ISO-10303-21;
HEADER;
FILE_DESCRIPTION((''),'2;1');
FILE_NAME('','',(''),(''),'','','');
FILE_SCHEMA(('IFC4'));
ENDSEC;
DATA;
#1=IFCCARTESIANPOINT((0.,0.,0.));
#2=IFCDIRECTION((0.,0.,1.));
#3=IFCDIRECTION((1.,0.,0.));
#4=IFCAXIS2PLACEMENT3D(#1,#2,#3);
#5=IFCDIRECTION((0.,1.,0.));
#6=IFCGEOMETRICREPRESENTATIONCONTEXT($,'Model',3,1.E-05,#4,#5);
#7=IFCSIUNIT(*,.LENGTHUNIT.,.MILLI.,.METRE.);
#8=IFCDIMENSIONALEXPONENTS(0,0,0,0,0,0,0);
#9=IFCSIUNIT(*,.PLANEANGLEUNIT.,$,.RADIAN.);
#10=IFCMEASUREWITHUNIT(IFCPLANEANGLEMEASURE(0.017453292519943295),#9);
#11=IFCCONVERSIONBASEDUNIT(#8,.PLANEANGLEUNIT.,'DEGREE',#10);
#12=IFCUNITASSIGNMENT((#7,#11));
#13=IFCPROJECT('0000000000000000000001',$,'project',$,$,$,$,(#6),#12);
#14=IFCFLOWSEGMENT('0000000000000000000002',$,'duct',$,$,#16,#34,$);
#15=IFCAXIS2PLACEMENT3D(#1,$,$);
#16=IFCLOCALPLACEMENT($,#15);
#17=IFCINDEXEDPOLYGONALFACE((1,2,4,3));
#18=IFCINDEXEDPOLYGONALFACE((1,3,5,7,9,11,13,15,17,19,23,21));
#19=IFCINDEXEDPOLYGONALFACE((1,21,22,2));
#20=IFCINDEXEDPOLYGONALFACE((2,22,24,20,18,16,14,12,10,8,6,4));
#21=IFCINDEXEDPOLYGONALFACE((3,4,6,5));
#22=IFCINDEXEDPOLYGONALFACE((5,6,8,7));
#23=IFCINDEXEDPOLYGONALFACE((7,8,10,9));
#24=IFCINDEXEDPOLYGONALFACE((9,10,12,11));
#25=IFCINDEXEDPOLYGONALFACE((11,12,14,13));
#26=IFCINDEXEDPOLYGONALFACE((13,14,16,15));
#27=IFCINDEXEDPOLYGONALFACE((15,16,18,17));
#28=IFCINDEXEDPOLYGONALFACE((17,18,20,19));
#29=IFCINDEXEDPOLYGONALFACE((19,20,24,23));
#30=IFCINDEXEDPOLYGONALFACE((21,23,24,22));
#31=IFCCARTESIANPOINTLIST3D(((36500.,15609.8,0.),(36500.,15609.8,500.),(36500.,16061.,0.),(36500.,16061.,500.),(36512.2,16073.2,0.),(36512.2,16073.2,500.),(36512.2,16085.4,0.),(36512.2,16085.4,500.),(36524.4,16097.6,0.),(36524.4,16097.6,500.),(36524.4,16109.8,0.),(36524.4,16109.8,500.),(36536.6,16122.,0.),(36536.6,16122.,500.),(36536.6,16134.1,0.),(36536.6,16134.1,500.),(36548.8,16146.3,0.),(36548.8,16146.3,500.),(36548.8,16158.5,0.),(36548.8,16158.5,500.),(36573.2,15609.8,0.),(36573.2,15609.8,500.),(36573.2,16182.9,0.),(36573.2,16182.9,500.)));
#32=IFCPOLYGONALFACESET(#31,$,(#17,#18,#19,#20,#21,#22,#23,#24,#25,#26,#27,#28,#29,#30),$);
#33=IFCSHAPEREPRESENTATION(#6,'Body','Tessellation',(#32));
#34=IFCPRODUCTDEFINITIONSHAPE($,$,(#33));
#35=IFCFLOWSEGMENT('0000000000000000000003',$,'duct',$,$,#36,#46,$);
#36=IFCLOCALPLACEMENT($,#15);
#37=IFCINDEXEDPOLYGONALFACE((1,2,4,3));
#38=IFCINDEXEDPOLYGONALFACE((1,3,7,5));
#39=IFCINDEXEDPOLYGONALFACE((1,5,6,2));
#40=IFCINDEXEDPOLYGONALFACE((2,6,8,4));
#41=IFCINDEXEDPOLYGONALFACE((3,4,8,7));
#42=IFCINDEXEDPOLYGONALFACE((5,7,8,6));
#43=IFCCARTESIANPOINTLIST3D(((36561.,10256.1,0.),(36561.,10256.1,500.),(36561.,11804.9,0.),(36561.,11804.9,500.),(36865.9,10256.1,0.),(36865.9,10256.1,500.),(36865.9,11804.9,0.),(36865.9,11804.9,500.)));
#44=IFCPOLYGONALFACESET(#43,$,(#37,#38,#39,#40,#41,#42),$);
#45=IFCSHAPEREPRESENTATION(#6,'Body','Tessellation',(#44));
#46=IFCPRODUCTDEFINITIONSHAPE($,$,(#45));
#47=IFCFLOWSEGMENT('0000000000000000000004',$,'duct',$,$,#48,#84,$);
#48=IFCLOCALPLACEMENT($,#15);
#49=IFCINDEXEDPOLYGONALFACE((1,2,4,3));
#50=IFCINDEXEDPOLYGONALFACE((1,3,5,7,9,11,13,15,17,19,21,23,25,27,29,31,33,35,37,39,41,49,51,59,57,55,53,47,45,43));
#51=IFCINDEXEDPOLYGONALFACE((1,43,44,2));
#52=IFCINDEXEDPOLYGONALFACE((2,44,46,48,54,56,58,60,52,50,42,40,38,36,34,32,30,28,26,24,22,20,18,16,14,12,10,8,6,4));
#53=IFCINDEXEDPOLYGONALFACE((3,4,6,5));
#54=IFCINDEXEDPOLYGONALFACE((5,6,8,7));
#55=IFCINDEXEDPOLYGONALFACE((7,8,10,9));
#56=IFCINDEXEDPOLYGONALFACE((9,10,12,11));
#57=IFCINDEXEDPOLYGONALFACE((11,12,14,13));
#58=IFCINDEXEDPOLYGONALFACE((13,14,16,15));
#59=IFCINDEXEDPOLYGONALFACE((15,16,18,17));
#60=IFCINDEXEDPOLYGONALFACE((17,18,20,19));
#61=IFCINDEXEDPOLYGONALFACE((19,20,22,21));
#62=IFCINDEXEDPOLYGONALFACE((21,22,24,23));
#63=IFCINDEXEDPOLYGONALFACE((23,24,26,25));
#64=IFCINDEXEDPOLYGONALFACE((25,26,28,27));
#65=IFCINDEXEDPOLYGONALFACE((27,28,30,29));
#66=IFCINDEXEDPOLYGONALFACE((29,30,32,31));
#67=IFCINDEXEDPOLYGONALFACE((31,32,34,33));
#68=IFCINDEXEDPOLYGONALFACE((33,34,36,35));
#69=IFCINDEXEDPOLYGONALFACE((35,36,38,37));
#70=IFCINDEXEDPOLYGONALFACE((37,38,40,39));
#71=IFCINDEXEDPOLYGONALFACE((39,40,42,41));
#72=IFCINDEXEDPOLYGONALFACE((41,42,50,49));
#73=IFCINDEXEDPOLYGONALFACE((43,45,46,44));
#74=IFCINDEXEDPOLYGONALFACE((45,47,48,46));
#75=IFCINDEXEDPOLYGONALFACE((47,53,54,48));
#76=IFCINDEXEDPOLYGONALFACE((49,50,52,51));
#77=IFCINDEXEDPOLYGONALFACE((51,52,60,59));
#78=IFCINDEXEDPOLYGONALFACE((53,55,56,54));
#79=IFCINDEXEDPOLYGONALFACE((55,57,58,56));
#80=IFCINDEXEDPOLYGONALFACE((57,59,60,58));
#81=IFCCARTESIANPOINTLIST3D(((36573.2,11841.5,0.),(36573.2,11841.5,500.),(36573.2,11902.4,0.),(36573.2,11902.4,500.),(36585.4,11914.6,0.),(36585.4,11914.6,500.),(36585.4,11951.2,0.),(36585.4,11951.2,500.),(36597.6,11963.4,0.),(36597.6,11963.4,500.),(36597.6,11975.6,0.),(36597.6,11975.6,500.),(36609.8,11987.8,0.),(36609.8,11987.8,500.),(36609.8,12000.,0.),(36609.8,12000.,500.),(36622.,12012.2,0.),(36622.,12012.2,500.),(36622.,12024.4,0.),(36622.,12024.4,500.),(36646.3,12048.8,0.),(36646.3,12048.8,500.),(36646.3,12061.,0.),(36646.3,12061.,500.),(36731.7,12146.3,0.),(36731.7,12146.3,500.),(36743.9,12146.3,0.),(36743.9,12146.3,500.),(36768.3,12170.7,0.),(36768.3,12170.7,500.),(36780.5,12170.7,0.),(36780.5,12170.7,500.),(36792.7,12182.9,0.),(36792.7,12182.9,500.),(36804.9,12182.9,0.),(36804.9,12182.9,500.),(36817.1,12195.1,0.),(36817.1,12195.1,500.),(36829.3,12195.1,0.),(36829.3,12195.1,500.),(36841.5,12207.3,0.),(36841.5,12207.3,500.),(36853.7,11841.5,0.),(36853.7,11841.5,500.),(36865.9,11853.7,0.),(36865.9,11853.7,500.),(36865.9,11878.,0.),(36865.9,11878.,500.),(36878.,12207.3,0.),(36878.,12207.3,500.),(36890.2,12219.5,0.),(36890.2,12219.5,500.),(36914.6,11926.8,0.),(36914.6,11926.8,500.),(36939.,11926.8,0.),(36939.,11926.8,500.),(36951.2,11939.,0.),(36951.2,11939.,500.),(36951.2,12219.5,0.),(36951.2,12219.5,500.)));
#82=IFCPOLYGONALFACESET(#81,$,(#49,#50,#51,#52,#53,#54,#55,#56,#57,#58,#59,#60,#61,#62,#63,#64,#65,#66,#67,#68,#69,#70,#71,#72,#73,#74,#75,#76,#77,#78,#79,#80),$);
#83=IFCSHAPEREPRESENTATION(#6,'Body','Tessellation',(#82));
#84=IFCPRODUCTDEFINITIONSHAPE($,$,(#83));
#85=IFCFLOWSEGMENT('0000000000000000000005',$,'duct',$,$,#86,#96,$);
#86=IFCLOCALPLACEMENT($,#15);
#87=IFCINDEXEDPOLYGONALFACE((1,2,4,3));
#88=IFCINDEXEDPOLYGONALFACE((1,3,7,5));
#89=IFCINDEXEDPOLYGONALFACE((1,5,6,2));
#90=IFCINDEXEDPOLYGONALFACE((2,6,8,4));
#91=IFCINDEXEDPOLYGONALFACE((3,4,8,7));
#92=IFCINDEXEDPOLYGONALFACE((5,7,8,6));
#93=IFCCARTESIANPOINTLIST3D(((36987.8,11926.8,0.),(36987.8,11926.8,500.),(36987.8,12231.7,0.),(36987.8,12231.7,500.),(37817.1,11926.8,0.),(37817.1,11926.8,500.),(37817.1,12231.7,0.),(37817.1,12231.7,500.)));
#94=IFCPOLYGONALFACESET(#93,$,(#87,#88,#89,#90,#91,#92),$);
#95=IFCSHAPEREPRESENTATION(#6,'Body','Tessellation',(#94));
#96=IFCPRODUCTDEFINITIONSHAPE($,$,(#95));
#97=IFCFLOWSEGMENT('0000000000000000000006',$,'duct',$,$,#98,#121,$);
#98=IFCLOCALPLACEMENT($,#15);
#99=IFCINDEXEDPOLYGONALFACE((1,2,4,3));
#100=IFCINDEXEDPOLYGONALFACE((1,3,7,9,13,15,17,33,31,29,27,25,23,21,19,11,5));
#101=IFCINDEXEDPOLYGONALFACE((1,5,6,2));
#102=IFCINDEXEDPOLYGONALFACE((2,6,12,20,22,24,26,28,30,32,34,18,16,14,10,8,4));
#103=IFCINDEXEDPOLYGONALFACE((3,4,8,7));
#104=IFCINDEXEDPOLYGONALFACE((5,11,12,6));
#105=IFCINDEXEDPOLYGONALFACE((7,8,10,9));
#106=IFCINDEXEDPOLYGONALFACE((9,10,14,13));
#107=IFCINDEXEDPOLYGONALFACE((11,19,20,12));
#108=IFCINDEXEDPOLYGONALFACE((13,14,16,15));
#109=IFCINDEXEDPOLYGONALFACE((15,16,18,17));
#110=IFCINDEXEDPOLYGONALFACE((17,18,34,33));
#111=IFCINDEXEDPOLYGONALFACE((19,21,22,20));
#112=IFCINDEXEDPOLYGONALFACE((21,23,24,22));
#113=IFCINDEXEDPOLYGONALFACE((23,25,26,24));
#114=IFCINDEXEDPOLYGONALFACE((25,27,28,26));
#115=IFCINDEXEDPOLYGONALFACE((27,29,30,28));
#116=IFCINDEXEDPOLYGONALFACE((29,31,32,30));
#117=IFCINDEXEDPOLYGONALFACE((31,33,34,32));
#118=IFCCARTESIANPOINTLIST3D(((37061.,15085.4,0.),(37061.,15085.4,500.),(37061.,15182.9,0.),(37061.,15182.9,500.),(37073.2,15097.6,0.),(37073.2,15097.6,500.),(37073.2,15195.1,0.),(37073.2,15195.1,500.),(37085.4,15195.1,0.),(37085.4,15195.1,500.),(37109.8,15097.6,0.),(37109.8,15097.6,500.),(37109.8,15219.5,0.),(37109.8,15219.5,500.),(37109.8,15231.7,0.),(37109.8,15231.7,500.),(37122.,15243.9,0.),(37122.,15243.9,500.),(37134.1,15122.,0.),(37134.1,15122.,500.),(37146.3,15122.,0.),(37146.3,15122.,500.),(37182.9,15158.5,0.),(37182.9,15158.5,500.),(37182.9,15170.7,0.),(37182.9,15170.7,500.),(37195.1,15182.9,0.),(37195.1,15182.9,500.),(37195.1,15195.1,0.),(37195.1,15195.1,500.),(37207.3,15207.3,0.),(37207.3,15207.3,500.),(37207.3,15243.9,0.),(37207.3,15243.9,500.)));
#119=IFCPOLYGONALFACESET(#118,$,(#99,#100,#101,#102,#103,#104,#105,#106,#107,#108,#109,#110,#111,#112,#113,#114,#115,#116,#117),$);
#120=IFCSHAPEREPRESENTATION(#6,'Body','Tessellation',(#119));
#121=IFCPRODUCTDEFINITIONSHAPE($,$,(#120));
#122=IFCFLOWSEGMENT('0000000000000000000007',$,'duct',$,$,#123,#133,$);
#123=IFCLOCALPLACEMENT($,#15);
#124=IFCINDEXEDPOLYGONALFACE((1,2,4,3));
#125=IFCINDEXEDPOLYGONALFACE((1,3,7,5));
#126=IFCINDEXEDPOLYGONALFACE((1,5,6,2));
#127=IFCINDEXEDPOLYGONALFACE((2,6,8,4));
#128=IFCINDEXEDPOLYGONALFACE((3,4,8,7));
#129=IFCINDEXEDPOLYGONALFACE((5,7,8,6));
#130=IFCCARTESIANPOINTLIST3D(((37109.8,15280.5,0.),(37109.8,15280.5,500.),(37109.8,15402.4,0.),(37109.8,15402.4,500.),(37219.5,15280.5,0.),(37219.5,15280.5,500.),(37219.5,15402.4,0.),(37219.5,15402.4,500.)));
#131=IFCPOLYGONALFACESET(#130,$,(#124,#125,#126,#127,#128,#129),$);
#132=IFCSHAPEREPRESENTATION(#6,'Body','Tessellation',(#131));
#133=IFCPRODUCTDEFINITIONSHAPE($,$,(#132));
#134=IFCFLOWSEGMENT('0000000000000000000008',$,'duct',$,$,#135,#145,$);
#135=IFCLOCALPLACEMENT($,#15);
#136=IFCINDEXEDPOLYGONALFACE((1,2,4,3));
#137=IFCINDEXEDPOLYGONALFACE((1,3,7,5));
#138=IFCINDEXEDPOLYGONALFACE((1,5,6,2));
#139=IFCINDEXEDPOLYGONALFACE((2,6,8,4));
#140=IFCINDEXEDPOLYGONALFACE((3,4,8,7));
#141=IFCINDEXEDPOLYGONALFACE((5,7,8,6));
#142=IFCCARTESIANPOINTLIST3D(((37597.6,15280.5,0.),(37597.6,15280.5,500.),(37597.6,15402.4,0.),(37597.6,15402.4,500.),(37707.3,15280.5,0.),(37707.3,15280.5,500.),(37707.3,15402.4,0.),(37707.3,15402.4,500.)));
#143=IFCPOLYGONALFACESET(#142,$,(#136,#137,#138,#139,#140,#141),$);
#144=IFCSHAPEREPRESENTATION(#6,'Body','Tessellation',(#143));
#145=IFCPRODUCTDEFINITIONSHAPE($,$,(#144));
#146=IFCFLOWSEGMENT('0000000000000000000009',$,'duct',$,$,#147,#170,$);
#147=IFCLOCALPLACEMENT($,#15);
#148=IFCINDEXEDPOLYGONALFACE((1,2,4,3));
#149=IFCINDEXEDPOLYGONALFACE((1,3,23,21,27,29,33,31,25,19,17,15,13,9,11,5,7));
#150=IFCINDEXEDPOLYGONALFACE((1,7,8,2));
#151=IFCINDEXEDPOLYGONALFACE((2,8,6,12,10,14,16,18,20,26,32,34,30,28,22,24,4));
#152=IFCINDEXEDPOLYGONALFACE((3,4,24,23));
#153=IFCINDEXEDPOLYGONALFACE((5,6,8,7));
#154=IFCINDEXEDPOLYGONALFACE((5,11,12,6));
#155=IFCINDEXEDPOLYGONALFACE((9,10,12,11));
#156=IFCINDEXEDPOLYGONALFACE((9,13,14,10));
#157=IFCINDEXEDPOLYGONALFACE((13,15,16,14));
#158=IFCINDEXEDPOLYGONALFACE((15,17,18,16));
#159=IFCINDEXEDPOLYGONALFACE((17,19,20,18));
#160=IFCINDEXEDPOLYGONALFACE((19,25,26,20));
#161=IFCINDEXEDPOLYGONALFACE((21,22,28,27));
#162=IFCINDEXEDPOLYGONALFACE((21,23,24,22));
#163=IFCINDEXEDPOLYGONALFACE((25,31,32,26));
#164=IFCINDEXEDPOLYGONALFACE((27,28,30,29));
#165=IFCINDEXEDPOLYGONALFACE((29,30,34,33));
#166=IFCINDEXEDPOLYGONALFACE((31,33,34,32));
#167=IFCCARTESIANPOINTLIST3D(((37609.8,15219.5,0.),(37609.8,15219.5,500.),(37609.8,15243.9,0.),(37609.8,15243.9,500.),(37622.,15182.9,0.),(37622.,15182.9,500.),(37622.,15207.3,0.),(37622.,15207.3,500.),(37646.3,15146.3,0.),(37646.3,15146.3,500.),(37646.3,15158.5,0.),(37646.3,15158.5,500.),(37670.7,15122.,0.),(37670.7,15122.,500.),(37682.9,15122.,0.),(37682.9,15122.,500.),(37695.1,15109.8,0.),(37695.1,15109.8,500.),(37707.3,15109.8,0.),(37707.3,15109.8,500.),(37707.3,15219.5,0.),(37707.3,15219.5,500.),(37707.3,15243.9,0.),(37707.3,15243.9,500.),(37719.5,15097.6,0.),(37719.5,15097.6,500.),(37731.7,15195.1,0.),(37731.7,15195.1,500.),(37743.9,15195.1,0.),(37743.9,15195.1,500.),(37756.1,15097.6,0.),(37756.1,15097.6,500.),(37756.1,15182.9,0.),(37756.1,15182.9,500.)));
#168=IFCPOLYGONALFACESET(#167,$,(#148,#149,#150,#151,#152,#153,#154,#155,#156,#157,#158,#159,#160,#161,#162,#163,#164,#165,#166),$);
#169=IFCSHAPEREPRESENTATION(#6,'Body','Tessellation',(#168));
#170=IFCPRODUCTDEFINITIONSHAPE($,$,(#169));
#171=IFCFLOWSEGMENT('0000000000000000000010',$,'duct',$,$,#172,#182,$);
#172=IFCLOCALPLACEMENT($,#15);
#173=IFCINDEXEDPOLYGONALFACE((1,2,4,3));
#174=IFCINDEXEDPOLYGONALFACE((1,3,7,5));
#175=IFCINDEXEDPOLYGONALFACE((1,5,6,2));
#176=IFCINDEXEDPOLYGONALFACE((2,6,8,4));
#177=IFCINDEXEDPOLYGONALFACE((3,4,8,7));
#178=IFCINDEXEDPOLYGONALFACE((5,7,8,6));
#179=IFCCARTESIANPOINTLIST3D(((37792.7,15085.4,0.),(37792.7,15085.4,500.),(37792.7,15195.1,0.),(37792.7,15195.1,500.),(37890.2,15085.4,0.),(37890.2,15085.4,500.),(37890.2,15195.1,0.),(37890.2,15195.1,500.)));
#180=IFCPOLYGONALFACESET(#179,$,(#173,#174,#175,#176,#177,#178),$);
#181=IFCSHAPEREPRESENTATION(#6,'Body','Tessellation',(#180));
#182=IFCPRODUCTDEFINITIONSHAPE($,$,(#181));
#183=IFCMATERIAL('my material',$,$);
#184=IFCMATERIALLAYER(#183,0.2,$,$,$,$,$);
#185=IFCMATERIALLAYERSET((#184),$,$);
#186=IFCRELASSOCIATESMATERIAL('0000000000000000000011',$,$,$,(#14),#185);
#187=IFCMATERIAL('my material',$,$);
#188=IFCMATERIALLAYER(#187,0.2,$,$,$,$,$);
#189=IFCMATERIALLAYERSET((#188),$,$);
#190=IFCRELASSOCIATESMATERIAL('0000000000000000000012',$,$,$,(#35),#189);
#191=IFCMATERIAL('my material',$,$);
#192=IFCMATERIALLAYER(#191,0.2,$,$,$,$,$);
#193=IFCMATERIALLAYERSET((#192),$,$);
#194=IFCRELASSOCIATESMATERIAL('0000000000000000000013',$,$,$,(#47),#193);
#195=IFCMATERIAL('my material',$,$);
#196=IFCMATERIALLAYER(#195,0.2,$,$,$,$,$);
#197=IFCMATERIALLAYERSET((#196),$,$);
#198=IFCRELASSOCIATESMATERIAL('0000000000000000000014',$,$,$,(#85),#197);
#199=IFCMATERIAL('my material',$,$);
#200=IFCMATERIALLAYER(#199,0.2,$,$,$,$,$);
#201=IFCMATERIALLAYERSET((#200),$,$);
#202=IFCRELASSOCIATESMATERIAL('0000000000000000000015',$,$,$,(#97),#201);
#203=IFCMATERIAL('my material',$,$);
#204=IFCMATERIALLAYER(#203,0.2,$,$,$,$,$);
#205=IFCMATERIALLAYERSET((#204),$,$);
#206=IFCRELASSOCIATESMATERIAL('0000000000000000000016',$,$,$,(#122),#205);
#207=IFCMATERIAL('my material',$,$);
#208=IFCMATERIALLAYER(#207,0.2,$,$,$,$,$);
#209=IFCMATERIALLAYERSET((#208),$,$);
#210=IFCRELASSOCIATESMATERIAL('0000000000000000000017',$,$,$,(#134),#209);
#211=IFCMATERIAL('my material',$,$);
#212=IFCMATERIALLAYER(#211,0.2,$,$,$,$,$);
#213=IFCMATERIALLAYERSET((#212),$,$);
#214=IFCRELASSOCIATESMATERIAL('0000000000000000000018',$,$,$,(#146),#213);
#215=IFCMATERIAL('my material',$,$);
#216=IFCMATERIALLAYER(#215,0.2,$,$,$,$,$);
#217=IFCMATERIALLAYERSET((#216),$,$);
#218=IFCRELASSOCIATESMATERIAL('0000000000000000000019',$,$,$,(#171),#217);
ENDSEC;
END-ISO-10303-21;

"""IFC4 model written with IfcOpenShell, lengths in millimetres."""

from ifc_helpers import new_model, entity, si_unit, converted_unit, direction, origin_with_axes, place, context, project, polyline, outline, extrude, material, layer, layer_set, layer_usage, element, save


model = new_model("IFC4")

# Units and contexts
model_context = context("Model", 3, precision=1e-05, world=origin_with_axes(), true_north=direction((0.0, 1.0, 0.0)))
ifc_project = project(units=[si_unit("LENGTHUNIT", "METRE", prefix="MILLI"), converted_unit("PLANEANGLEUNIT", "DEGREE", entity("IfcPlaneAngleMeasure", 0.017453292519943295), si_unit("PLANEANGLEUNIT", "RADIAN"), dimensions=[0, 0, 0, 0, 0, 0, 0])], contexts=[model_context])

# Flow segments
ifc_material_1 = material(Name="my material")
ifc_layer_1 = layer(ifc_material_1, 0.2)
ifc_layer_set_1 = layer_set([ifc_layer_1])
ifc_layer_usage_1 = layer_usage(ifc_layer_set_1, "AXIS2", "POSITIVE", -0.1)
flow_segment_1_placement = place(None, origin_with_axes())
element("IfcFlowSegment", 1, at=flow_segment_1_placement, material=ifc_layer_usage_1, Name="duct", context=model_context, shape_type="SweptSolid", body=[
    extrude(outline(polyline([(36500.0, 15609.8), (36573.2, 15609.8), (36573.2, 16195.1), (36573.2, 16182.9), (36548.8, 16158.5), (36548.8, 16146.3), (36536.6, 16134.1), (36536.6, 16122.0), (36524.4, 16109.8), (36524.4, 16097.6), (36512.2, 16085.4), (36512.2, 16073.2), (36500.0, 16061.0), (36500.0, 15609.8)])), origin_with_axes(), (0.0, 0.0, 1.0), 500.0),
])
ifc_material_2 = material(Name="my material")
ifc_layer_2 = layer(ifc_material_2, 0.2)
ifc_layer_set_2 = layer_set([ifc_layer_2])
ifc_layer_usage_2 = layer_usage(ifc_layer_set_2, "AXIS2", "POSITIVE", -0.1)
flow_segment_2_placement = place(None, origin_with_axes())
element("IfcFlowSegment", 2, at=flow_segment_2_placement, material=ifc_layer_usage_2, Name="duct", context=model_context, shape_type="SweptSolid", body=[
    extrude(outline(polyline([(36561.0, 10256.1), (36865.9, 10256.1), (36865.9, 11804.9), (36561.0, 11804.9), (36561.0, 10256.1)])), origin_with_axes(), (0.0, 0.0, 1.0), 500.0),
])
ifc_material_3 = material(Name="my material")
ifc_layer_3 = layer(ifc_material_3, 0.2)
ifc_layer_set_3 = layer_set([ifc_layer_3])
ifc_layer_usage_3 = layer_usage(ifc_layer_set_3, "AXIS2", "POSITIVE", -0.1)
flow_segment_3_placement = place(None, origin_with_axes())
element("IfcFlowSegment", 3, at=flow_segment_3_placement, material=ifc_layer_usage_3, Name="duct", context=model_context, shape_type="SweptSolid", body=[
    extrude(outline(polyline([(36573.2, 11841.5), (36853.7, 11841.5), (36865.9, 11853.7), (36865.9, 11878.0), (36914.6, 11926.8), (36939.0, 11926.8), (36951.2, 11939.0), (36951.2, 12219.5), (36890.2, 12219.5), (36878.0, 12207.3), (36841.5, 12207.3), (36829.3, 12195.1), (36817.1, 12195.1), (36804.9, 12182.9), (36792.7, 12182.9), (36780.5, 12170.7), (36768.3, 12170.7), (36743.9, 12146.3), (36731.7, 12146.3), (36646.3, 12061.0), (36646.3, 12048.8), (36622.0, 12024.4), (36622.0, 12012.2), (36609.8, 12000.0), (36609.8, 11987.8), (36597.6, 11975.6), (36597.6, 11963.4), (36585.4, 11951.2), (36585.4, 11914.6), (36573.2, 11902.4), (36573.2, 11841.5)])), origin_with_axes(), (0.0, 0.0, 1.0), 500.0),
])
ifc_material_4 = material(Name="my material")
ifc_layer_4 = layer(ifc_material_4, 0.2)
ifc_layer_set_4 = layer_set([ifc_layer_4])
ifc_layer_usage_4 = layer_usage(ifc_layer_set_4, "AXIS2", "POSITIVE", -0.1)
flow_segment_4_placement = place(None, origin_with_axes())
element("IfcFlowSegment", 4, at=flow_segment_4_placement, material=ifc_layer_usage_4, Name="duct", context=model_context, shape_type="SweptSolid", body=[
    extrude(outline(polyline([(36987.8, 11926.8), (37817.1, 11926.8), (37817.1, 12231.7), (36987.8, 12231.7), (36987.8, 11926.8)])), origin_with_axes(), (0.0, 0.0, 1.0), 500.0),
])
ifc_material_5 = material(Name="my material")
ifc_layer_5 = layer(ifc_material_5, 0.2)
ifc_layer_set_5 = layer_set([ifc_layer_5])
ifc_layer_usage_5 = layer_usage(ifc_layer_set_5, "AXIS2", "POSITIVE", -0.1)
flow_segment_5_placement = place(None, origin_with_axes())
element("IfcFlowSegment", 5, at=flow_segment_5_placement, material=ifc_layer_usage_5, Name="duct", context=model_context, shape_type="SweptSolid", body=[
    extrude(outline(polyline([(37061.0, 15085.4), (37073.2, 15097.6), (37109.8, 15097.6), (37134.1, 15122.0), (37146.3, 15122.0), (37182.9, 15158.5), (37182.9, 15170.7), (37195.1, 15182.9), (37195.1, 15195.1), (37207.3, 15207.3), (37207.3, 15243.9), (37122.0, 15243.9), (37109.8, 15231.7), (37109.8, 15219.5), (37085.4, 15195.1), (37073.2, 15195.1), (37061.0, 15182.9), (37061.0, 15085.4)])), origin_with_axes(), (0.0, 0.0, 1.0), 500.0),
])
ifc_material_6 = material(Name="my material")
ifc_layer_6 = layer(ifc_material_6, 0.2)
ifc_layer_set_6 = layer_set([ifc_layer_6])
ifc_layer_usage_6 = layer_usage(ifc_layer_set_6, "AXIS2", "POSITIVE", -0.1)
flow_segment_6_placement = place(None, origin_with_axes())
element("IfcFlowSegment", 6, at=flow_segment_6_placement, material=ifc_layer_usage_6, Name="duct", context=model_context, shape_type="SweptSolid", body=[
    extrude(outline(polyline([(37109.8, 15280.5), (37219.5, 15280.5), (37219.5, 15402.4), (37109.8, 15402.4), (37109.8, 15280.5)])), origin_with_axes(), (0.0, 0.0, 1.0), 500.0),
])
ifc_material_7 = material(Name="my material")
ifc_layer_7 = layer(ifc_material_7, 0.2)
ifc_layer_set_7 = layer_set([ifc_layer_7])
ifc_layer_usage_7 = layer_usage(ifc_layer_set_7, "AXIS2", "POSITIVE", -0.1)
flow_segment_7_placement = place(None, origin_with_axes())
element("IfcFlowSegment", 7, at=flow_segment_7_placement, material=ifc_layer_usage_7, Name="duct", context=model_context, shape_type="SweptSolid", body=[
    extrude(outline(polyline([(37597.6, 15280.5), (37707.3, 15280.5), (37707.3, 15402.4), (37597.6, 15402.4), (37597.6, 15280.5)])), origin_with_axes(), (0.0, 0.0, 1.0), 500.0),
])
ifc_material_8 = material(Name="my material")
ifc_layer_8 = layer(ifc_material_8, 0.2)
ifc_layer_set_8 = layer_set([ifc_layer_8])
ifc_layer_usage_8 = layer_usage(ifc_layer_set_8, "AXIS2", "POSITIVE", -0.1)
flow_segment_8_placement = place(None, origin_with_axes())
element("IfcFlowSegment", 8, at=flow_segment_8_placement, material=ifc_layer_usage_8, Name="duct", context=model_context, shape_type="SweptSolid", body=[
    extrude(outline(polyline([(37609.8, 15219.5), (37622.0, 15207.3), (37622.0, 15182.9), (37646.3, 15158.5), (37646.3, 15146.3), (37670.7, 15122.0), (37682.9, 15122.0), (37695.1, 15109.8), (37707.3, 15109.8), (37719.5, 15097.6), (37756.1, 15097.6), (37756.1, 15182.9), (37743.9, 15195.1), (37731.7, 15195.1), (37707.3, 15219.5), (37707.3, 15243.9), (37609.8, 15243.9), (37609.8, 15219.5)])), origin_with_axes(), (0.0, 0.0, 1.0), 500.0),
])
ifc_material_9 = material(Name="my material")
ifc_layer_9 = layer(ifc_material_9, 0.2)
ifc_layer_set_9 = layer_set([ifc_layer_9])
ifc_layer_usage_9 = layer_usage(ifc_layer_set_9, "AXIS2", "POSITIVE", -0.1)
flow_segment_9_placement = place(None, origin_with_axes())
element("IfcFlowSegment", 9, at=flow_segment_9_placement, material=ifc_layer_usage_9, Name="duct", context=model_context, shape_type="SweptSolid", body=[
    extrude(outline(polyline([(37792.7, 15085.4), (37890.2, 15085.4), (37890.2, 15195.1), (37792.7, 15195.1), (37792.7, 15085.4)])), origin_with_axes(), (0.0, 0.0, 1.0), 500.0),
])

save(model, "model.ifc")
